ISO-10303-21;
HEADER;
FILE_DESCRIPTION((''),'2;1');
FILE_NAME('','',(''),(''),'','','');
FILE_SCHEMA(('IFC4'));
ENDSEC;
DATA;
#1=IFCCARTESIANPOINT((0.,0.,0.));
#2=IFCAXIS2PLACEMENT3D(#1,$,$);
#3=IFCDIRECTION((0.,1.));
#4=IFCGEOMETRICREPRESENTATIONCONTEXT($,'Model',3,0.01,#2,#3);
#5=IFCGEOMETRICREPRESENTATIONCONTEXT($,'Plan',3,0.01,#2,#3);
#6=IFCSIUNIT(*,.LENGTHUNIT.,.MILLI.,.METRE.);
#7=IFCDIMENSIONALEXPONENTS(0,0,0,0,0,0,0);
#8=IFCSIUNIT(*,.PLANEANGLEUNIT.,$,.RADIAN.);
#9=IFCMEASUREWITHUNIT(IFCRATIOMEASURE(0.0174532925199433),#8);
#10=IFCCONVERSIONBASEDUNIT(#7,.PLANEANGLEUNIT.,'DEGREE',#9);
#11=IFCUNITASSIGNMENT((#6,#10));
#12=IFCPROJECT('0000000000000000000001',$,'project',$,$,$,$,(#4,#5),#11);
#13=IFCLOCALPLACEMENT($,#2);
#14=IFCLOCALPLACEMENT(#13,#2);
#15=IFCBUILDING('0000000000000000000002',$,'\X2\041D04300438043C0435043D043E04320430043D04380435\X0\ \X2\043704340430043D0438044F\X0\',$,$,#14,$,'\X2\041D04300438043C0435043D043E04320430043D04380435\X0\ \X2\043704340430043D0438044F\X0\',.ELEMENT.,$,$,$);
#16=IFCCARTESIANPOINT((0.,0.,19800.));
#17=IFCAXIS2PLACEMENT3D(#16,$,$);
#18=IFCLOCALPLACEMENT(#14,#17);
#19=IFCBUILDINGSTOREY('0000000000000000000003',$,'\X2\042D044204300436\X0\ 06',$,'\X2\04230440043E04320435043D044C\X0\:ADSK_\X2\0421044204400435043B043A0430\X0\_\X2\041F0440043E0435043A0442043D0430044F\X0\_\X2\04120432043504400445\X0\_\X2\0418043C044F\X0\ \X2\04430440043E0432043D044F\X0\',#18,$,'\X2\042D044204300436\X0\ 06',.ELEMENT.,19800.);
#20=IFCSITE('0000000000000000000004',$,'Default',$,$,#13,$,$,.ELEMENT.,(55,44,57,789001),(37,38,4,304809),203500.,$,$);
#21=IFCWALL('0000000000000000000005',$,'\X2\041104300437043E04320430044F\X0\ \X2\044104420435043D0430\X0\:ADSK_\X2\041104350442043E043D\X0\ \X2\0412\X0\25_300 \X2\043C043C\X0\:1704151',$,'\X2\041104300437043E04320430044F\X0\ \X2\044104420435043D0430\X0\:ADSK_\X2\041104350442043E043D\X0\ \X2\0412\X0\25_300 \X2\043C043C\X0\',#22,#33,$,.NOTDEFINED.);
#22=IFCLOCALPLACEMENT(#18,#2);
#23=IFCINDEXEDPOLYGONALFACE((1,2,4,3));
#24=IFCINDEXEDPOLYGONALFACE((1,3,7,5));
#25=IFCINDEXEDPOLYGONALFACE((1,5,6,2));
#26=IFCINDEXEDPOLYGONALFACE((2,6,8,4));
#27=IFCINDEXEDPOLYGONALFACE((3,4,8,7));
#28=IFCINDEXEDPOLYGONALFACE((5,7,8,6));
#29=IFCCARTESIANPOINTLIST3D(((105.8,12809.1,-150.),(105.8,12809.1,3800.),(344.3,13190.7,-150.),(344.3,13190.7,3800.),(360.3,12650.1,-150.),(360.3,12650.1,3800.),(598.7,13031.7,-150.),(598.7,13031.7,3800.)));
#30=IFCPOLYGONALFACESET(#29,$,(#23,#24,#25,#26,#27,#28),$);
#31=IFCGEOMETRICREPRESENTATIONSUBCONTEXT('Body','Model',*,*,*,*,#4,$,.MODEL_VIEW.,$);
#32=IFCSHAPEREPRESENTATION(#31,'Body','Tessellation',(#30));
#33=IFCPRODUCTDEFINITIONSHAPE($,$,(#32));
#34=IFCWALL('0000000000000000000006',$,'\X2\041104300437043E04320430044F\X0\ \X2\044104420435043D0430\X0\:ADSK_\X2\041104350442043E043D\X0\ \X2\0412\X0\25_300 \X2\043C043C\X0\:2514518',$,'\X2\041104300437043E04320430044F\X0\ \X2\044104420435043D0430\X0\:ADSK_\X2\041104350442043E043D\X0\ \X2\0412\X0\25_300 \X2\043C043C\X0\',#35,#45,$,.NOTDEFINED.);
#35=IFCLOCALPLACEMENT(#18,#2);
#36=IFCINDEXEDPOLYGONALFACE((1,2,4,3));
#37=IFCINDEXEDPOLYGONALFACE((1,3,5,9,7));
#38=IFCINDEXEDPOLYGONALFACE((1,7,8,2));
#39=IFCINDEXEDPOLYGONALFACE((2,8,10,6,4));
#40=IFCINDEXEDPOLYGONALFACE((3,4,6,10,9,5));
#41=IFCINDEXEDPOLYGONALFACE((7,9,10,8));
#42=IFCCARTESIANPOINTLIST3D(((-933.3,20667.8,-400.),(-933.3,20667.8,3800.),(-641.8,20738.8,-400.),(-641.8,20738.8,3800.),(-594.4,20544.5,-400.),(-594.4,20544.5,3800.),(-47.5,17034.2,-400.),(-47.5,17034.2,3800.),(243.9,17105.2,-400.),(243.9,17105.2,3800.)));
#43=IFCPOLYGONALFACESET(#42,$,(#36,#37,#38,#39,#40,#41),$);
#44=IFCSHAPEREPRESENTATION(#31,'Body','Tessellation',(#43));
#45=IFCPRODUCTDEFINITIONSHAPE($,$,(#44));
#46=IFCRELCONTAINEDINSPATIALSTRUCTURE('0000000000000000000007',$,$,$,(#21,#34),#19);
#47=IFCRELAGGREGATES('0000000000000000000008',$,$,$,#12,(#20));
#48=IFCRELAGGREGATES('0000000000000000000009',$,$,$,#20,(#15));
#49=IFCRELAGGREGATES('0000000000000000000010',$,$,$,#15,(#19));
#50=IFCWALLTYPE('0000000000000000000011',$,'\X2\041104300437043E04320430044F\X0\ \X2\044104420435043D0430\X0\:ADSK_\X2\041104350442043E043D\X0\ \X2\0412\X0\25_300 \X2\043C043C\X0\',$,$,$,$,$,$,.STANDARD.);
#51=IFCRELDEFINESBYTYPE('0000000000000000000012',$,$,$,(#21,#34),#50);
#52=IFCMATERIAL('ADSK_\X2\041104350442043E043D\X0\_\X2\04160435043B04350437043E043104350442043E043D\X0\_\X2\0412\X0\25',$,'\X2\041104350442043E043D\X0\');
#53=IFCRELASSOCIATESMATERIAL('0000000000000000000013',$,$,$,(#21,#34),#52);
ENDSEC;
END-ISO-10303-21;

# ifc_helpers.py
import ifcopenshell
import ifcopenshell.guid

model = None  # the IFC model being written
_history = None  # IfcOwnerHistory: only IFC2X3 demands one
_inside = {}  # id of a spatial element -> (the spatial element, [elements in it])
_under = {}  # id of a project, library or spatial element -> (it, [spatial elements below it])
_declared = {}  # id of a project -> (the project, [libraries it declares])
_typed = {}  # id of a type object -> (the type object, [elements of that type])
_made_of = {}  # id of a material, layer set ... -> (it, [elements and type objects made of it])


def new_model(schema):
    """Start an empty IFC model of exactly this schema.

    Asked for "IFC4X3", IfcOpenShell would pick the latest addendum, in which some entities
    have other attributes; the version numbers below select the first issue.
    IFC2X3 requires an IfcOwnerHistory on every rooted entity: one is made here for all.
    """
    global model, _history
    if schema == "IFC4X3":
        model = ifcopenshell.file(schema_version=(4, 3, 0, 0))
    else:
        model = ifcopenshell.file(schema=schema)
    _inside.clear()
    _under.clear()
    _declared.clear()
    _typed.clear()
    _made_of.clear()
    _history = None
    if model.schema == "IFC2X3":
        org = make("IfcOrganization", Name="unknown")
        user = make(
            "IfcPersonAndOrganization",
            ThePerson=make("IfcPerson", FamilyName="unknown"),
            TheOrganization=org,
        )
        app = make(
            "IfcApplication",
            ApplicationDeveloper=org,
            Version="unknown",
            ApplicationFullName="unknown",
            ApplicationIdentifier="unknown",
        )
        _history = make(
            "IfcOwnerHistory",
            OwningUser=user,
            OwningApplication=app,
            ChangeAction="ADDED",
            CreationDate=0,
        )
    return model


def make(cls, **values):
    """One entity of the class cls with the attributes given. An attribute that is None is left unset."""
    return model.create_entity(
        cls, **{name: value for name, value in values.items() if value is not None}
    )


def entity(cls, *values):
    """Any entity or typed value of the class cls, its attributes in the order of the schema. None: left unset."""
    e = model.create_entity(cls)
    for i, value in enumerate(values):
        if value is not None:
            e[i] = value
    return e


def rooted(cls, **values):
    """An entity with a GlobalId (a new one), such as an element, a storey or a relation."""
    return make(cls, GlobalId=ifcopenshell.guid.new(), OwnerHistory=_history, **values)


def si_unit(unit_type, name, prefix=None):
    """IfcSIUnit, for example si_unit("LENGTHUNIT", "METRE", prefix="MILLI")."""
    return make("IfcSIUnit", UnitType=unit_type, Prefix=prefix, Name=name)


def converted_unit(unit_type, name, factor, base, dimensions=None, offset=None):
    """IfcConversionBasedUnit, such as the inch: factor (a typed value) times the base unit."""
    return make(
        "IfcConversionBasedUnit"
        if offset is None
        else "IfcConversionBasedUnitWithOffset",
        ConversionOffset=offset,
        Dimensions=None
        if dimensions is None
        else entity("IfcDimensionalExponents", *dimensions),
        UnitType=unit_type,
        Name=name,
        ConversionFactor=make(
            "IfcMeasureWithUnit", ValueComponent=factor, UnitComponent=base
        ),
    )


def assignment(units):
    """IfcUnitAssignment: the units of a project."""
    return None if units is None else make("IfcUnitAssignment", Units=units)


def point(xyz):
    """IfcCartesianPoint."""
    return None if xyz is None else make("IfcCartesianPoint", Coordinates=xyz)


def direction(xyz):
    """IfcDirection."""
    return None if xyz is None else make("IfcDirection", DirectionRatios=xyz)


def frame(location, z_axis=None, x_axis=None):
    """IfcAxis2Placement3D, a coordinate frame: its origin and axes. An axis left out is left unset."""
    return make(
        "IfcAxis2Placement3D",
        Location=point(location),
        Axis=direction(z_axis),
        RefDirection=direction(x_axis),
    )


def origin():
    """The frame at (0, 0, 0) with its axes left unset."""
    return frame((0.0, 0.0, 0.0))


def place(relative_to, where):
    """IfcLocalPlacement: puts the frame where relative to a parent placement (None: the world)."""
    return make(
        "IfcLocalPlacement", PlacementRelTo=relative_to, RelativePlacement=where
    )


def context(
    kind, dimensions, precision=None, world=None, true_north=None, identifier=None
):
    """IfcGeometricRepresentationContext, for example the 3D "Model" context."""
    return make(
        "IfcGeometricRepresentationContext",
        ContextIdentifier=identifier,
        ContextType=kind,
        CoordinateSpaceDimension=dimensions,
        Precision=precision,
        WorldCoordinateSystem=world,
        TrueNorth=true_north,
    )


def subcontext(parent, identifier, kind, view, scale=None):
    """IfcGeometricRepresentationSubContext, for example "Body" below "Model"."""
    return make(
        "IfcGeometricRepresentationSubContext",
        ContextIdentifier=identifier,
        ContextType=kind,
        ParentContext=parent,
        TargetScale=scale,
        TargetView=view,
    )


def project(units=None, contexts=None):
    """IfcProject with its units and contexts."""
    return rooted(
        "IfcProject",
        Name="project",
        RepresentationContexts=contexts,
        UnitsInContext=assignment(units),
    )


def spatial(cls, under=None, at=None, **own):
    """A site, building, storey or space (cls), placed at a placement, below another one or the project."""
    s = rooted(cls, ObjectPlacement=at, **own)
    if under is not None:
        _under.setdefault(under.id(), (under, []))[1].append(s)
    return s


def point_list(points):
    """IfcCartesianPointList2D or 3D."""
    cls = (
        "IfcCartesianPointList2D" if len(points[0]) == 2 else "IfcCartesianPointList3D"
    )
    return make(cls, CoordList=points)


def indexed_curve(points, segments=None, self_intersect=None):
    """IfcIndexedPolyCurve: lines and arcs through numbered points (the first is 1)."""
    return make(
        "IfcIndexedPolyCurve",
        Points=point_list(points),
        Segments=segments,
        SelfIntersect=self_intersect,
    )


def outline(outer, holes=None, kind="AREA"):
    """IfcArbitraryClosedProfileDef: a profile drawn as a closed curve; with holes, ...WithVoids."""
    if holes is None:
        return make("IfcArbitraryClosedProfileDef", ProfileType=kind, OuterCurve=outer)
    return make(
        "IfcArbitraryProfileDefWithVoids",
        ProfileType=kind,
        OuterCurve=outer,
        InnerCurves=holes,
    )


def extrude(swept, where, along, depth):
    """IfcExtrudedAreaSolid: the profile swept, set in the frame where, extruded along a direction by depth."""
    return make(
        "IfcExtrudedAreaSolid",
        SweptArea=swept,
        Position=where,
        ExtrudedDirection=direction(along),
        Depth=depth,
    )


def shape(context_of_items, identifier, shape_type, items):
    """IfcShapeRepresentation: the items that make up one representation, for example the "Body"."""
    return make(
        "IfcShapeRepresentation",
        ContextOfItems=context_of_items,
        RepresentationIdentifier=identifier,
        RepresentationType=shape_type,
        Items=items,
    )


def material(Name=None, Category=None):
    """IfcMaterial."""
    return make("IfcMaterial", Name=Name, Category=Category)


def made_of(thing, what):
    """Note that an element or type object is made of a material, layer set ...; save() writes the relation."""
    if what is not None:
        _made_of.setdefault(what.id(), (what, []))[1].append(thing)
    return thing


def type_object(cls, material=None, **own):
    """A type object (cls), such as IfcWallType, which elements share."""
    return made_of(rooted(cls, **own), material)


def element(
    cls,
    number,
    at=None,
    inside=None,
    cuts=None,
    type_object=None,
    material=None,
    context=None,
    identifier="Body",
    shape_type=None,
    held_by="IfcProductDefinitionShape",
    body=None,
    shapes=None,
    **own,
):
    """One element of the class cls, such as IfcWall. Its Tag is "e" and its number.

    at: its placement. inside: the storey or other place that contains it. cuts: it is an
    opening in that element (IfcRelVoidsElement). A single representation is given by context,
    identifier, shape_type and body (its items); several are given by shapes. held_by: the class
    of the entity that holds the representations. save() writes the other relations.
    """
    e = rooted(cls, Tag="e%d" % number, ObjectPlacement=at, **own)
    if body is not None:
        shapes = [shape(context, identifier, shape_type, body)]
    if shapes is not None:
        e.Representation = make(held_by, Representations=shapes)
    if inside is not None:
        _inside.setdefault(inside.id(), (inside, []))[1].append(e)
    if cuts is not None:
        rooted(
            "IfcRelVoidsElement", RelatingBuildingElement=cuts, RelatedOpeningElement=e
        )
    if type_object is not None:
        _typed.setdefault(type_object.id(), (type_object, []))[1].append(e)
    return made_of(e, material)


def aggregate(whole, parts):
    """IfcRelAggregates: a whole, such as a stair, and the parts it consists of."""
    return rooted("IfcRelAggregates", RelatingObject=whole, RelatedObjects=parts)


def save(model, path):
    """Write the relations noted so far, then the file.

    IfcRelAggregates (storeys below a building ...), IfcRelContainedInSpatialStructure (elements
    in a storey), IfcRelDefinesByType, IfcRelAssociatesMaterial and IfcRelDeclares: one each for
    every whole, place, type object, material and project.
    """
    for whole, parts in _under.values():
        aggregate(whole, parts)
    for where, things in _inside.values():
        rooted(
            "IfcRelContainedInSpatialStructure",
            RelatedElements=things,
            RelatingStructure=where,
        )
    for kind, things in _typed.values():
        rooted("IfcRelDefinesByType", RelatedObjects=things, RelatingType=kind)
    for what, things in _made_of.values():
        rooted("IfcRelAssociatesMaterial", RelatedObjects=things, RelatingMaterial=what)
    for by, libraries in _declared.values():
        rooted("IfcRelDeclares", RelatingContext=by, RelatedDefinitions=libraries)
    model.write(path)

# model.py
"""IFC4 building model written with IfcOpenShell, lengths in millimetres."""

from ifc_helpers import new_model, entity, si_unit, converted_unit, direction, frame, origin, place, context, subcontext, project, spatial, indexed_curve, outline, extrude, material, type_object, element, save


model = new_model("IFC4")

# Units and contexts
model_context = context("Model", 3, precision=0.01, world=origin(), true_north=direction((0.0, 1.0)))
plan_context = context("Plan", 3, precision=0.01, world=origin(), true_north=direction((0.0, 1.0)))
body_context = subcontext(model_context, "Body", "Model", "MODEL_VIEW")
ifc_project = project(units=[si_unit("LENGTHUNIT", "METRE", prefix="MILLI"), converted_unit("PLANEANGLEUNIT", "DEGREE", entity("IfcRatioMeasure", 0.0174532925199433), si_unit("PLANEANGLEUNIT", "RADIAN"), dimensions=[0, 0, 0, 0, 0, 0, 0])], contexts=[model_context, plan_context])

# Site, building, storey
site_placement = place(None, origin())
site = spatial("IfcSite", under=ifc_project, at=site_placement, Name="Default", CompositionType="ELEMENT", RefLatitude=(55, 44, 57, 789001), RefLongitude=(37, 38, 4, 304809), RefElevation=203500.0)
building_placement = place(site_placement, origin())
building = spatial("IfcBuilding", under=site, at=building_placement, Name="Наименование здания", LongName="Наименование здания", CompositionType="ELEMENT")
storey_placement = place(building_placement, frame((0.0, 0.0, 19800.0)))
storey = spatial("IfcBuildingStorey", under=building, at=storey_placement, Name="Этаж 06", ObjectType="Уровень:ADSK_Стрелка_Проектная_Вверх_Имя уровня", LongName="Этаж 06", CompositionType="ELEMENT", Elevation=19800.0)

# Shared definitions
ifc_material = material(Name="ADSK_Бетон_Железобетон_В25", Category="Бетон")

# Walls
wall_type = type_object("IfcWallType", Name="Базовая стена:ADSK_Бетон В25_300 мм", PredefinedType="STANDARD")
wall_1_placement = place(storey_placement, frame((233.1, 12729.6, -150.0), z_axis=(0.0, 0.0, 1.0), x_axis=(0.529912, 0.848053, 0.0)))
element("IfcWall", 1, at=wall_1_placement, inside=storey, type_object=wall_type, material=ifc_material, Name="Базовая стена:ADSK_Бетон В25_300 мм:1704151", ObjectType="Базовая стена:ADSK_Бетон В25_300 мм", PredefinedType="NOTDEFINED", context=body_context, shape_type="SweptSolid", body=[
    extrude(outline(indexed_curve([(450.0, 150.0), (0.0, 150.0), (0.0, -150.0), (450.0, -150.0), (450.0, 150.0)], self_intersect=False)), origin(), (0.0, 0.0, 1.0), 3950.0),
])
wall_2_placement = place(storey_placement, frame((98.2, 17069.7, -400.0), z_axis=(0.0, 0.0, 1.0), x_axis=(-0.236826, 0.971552, 0.0)))
element("IfcWall", 2, at=wall_2_placement, inside=storey, type_object=wall_type, material=ifc_material, Name="Базовая стена:ADSK_Бетон В25_300 мм:2514518", ObjectType="Базовая стена:ADSK_Бетон В25_300 мм", PredefinedType="NOTDEFINED", context=body_context, shape_type="SweptSolid", body=[
    extrude(outline(indexed_curve([(0.0, 150.0), (0.0, -150.0), (3540.0, -150.0), (3740.0, -150.0), (3740.0, 150.0), (0.0, 150.0)], self_intersect=False)), origin(), (0.0, 0.0, 1.0), 4200.0),
])

save(model, "model.ifc")
